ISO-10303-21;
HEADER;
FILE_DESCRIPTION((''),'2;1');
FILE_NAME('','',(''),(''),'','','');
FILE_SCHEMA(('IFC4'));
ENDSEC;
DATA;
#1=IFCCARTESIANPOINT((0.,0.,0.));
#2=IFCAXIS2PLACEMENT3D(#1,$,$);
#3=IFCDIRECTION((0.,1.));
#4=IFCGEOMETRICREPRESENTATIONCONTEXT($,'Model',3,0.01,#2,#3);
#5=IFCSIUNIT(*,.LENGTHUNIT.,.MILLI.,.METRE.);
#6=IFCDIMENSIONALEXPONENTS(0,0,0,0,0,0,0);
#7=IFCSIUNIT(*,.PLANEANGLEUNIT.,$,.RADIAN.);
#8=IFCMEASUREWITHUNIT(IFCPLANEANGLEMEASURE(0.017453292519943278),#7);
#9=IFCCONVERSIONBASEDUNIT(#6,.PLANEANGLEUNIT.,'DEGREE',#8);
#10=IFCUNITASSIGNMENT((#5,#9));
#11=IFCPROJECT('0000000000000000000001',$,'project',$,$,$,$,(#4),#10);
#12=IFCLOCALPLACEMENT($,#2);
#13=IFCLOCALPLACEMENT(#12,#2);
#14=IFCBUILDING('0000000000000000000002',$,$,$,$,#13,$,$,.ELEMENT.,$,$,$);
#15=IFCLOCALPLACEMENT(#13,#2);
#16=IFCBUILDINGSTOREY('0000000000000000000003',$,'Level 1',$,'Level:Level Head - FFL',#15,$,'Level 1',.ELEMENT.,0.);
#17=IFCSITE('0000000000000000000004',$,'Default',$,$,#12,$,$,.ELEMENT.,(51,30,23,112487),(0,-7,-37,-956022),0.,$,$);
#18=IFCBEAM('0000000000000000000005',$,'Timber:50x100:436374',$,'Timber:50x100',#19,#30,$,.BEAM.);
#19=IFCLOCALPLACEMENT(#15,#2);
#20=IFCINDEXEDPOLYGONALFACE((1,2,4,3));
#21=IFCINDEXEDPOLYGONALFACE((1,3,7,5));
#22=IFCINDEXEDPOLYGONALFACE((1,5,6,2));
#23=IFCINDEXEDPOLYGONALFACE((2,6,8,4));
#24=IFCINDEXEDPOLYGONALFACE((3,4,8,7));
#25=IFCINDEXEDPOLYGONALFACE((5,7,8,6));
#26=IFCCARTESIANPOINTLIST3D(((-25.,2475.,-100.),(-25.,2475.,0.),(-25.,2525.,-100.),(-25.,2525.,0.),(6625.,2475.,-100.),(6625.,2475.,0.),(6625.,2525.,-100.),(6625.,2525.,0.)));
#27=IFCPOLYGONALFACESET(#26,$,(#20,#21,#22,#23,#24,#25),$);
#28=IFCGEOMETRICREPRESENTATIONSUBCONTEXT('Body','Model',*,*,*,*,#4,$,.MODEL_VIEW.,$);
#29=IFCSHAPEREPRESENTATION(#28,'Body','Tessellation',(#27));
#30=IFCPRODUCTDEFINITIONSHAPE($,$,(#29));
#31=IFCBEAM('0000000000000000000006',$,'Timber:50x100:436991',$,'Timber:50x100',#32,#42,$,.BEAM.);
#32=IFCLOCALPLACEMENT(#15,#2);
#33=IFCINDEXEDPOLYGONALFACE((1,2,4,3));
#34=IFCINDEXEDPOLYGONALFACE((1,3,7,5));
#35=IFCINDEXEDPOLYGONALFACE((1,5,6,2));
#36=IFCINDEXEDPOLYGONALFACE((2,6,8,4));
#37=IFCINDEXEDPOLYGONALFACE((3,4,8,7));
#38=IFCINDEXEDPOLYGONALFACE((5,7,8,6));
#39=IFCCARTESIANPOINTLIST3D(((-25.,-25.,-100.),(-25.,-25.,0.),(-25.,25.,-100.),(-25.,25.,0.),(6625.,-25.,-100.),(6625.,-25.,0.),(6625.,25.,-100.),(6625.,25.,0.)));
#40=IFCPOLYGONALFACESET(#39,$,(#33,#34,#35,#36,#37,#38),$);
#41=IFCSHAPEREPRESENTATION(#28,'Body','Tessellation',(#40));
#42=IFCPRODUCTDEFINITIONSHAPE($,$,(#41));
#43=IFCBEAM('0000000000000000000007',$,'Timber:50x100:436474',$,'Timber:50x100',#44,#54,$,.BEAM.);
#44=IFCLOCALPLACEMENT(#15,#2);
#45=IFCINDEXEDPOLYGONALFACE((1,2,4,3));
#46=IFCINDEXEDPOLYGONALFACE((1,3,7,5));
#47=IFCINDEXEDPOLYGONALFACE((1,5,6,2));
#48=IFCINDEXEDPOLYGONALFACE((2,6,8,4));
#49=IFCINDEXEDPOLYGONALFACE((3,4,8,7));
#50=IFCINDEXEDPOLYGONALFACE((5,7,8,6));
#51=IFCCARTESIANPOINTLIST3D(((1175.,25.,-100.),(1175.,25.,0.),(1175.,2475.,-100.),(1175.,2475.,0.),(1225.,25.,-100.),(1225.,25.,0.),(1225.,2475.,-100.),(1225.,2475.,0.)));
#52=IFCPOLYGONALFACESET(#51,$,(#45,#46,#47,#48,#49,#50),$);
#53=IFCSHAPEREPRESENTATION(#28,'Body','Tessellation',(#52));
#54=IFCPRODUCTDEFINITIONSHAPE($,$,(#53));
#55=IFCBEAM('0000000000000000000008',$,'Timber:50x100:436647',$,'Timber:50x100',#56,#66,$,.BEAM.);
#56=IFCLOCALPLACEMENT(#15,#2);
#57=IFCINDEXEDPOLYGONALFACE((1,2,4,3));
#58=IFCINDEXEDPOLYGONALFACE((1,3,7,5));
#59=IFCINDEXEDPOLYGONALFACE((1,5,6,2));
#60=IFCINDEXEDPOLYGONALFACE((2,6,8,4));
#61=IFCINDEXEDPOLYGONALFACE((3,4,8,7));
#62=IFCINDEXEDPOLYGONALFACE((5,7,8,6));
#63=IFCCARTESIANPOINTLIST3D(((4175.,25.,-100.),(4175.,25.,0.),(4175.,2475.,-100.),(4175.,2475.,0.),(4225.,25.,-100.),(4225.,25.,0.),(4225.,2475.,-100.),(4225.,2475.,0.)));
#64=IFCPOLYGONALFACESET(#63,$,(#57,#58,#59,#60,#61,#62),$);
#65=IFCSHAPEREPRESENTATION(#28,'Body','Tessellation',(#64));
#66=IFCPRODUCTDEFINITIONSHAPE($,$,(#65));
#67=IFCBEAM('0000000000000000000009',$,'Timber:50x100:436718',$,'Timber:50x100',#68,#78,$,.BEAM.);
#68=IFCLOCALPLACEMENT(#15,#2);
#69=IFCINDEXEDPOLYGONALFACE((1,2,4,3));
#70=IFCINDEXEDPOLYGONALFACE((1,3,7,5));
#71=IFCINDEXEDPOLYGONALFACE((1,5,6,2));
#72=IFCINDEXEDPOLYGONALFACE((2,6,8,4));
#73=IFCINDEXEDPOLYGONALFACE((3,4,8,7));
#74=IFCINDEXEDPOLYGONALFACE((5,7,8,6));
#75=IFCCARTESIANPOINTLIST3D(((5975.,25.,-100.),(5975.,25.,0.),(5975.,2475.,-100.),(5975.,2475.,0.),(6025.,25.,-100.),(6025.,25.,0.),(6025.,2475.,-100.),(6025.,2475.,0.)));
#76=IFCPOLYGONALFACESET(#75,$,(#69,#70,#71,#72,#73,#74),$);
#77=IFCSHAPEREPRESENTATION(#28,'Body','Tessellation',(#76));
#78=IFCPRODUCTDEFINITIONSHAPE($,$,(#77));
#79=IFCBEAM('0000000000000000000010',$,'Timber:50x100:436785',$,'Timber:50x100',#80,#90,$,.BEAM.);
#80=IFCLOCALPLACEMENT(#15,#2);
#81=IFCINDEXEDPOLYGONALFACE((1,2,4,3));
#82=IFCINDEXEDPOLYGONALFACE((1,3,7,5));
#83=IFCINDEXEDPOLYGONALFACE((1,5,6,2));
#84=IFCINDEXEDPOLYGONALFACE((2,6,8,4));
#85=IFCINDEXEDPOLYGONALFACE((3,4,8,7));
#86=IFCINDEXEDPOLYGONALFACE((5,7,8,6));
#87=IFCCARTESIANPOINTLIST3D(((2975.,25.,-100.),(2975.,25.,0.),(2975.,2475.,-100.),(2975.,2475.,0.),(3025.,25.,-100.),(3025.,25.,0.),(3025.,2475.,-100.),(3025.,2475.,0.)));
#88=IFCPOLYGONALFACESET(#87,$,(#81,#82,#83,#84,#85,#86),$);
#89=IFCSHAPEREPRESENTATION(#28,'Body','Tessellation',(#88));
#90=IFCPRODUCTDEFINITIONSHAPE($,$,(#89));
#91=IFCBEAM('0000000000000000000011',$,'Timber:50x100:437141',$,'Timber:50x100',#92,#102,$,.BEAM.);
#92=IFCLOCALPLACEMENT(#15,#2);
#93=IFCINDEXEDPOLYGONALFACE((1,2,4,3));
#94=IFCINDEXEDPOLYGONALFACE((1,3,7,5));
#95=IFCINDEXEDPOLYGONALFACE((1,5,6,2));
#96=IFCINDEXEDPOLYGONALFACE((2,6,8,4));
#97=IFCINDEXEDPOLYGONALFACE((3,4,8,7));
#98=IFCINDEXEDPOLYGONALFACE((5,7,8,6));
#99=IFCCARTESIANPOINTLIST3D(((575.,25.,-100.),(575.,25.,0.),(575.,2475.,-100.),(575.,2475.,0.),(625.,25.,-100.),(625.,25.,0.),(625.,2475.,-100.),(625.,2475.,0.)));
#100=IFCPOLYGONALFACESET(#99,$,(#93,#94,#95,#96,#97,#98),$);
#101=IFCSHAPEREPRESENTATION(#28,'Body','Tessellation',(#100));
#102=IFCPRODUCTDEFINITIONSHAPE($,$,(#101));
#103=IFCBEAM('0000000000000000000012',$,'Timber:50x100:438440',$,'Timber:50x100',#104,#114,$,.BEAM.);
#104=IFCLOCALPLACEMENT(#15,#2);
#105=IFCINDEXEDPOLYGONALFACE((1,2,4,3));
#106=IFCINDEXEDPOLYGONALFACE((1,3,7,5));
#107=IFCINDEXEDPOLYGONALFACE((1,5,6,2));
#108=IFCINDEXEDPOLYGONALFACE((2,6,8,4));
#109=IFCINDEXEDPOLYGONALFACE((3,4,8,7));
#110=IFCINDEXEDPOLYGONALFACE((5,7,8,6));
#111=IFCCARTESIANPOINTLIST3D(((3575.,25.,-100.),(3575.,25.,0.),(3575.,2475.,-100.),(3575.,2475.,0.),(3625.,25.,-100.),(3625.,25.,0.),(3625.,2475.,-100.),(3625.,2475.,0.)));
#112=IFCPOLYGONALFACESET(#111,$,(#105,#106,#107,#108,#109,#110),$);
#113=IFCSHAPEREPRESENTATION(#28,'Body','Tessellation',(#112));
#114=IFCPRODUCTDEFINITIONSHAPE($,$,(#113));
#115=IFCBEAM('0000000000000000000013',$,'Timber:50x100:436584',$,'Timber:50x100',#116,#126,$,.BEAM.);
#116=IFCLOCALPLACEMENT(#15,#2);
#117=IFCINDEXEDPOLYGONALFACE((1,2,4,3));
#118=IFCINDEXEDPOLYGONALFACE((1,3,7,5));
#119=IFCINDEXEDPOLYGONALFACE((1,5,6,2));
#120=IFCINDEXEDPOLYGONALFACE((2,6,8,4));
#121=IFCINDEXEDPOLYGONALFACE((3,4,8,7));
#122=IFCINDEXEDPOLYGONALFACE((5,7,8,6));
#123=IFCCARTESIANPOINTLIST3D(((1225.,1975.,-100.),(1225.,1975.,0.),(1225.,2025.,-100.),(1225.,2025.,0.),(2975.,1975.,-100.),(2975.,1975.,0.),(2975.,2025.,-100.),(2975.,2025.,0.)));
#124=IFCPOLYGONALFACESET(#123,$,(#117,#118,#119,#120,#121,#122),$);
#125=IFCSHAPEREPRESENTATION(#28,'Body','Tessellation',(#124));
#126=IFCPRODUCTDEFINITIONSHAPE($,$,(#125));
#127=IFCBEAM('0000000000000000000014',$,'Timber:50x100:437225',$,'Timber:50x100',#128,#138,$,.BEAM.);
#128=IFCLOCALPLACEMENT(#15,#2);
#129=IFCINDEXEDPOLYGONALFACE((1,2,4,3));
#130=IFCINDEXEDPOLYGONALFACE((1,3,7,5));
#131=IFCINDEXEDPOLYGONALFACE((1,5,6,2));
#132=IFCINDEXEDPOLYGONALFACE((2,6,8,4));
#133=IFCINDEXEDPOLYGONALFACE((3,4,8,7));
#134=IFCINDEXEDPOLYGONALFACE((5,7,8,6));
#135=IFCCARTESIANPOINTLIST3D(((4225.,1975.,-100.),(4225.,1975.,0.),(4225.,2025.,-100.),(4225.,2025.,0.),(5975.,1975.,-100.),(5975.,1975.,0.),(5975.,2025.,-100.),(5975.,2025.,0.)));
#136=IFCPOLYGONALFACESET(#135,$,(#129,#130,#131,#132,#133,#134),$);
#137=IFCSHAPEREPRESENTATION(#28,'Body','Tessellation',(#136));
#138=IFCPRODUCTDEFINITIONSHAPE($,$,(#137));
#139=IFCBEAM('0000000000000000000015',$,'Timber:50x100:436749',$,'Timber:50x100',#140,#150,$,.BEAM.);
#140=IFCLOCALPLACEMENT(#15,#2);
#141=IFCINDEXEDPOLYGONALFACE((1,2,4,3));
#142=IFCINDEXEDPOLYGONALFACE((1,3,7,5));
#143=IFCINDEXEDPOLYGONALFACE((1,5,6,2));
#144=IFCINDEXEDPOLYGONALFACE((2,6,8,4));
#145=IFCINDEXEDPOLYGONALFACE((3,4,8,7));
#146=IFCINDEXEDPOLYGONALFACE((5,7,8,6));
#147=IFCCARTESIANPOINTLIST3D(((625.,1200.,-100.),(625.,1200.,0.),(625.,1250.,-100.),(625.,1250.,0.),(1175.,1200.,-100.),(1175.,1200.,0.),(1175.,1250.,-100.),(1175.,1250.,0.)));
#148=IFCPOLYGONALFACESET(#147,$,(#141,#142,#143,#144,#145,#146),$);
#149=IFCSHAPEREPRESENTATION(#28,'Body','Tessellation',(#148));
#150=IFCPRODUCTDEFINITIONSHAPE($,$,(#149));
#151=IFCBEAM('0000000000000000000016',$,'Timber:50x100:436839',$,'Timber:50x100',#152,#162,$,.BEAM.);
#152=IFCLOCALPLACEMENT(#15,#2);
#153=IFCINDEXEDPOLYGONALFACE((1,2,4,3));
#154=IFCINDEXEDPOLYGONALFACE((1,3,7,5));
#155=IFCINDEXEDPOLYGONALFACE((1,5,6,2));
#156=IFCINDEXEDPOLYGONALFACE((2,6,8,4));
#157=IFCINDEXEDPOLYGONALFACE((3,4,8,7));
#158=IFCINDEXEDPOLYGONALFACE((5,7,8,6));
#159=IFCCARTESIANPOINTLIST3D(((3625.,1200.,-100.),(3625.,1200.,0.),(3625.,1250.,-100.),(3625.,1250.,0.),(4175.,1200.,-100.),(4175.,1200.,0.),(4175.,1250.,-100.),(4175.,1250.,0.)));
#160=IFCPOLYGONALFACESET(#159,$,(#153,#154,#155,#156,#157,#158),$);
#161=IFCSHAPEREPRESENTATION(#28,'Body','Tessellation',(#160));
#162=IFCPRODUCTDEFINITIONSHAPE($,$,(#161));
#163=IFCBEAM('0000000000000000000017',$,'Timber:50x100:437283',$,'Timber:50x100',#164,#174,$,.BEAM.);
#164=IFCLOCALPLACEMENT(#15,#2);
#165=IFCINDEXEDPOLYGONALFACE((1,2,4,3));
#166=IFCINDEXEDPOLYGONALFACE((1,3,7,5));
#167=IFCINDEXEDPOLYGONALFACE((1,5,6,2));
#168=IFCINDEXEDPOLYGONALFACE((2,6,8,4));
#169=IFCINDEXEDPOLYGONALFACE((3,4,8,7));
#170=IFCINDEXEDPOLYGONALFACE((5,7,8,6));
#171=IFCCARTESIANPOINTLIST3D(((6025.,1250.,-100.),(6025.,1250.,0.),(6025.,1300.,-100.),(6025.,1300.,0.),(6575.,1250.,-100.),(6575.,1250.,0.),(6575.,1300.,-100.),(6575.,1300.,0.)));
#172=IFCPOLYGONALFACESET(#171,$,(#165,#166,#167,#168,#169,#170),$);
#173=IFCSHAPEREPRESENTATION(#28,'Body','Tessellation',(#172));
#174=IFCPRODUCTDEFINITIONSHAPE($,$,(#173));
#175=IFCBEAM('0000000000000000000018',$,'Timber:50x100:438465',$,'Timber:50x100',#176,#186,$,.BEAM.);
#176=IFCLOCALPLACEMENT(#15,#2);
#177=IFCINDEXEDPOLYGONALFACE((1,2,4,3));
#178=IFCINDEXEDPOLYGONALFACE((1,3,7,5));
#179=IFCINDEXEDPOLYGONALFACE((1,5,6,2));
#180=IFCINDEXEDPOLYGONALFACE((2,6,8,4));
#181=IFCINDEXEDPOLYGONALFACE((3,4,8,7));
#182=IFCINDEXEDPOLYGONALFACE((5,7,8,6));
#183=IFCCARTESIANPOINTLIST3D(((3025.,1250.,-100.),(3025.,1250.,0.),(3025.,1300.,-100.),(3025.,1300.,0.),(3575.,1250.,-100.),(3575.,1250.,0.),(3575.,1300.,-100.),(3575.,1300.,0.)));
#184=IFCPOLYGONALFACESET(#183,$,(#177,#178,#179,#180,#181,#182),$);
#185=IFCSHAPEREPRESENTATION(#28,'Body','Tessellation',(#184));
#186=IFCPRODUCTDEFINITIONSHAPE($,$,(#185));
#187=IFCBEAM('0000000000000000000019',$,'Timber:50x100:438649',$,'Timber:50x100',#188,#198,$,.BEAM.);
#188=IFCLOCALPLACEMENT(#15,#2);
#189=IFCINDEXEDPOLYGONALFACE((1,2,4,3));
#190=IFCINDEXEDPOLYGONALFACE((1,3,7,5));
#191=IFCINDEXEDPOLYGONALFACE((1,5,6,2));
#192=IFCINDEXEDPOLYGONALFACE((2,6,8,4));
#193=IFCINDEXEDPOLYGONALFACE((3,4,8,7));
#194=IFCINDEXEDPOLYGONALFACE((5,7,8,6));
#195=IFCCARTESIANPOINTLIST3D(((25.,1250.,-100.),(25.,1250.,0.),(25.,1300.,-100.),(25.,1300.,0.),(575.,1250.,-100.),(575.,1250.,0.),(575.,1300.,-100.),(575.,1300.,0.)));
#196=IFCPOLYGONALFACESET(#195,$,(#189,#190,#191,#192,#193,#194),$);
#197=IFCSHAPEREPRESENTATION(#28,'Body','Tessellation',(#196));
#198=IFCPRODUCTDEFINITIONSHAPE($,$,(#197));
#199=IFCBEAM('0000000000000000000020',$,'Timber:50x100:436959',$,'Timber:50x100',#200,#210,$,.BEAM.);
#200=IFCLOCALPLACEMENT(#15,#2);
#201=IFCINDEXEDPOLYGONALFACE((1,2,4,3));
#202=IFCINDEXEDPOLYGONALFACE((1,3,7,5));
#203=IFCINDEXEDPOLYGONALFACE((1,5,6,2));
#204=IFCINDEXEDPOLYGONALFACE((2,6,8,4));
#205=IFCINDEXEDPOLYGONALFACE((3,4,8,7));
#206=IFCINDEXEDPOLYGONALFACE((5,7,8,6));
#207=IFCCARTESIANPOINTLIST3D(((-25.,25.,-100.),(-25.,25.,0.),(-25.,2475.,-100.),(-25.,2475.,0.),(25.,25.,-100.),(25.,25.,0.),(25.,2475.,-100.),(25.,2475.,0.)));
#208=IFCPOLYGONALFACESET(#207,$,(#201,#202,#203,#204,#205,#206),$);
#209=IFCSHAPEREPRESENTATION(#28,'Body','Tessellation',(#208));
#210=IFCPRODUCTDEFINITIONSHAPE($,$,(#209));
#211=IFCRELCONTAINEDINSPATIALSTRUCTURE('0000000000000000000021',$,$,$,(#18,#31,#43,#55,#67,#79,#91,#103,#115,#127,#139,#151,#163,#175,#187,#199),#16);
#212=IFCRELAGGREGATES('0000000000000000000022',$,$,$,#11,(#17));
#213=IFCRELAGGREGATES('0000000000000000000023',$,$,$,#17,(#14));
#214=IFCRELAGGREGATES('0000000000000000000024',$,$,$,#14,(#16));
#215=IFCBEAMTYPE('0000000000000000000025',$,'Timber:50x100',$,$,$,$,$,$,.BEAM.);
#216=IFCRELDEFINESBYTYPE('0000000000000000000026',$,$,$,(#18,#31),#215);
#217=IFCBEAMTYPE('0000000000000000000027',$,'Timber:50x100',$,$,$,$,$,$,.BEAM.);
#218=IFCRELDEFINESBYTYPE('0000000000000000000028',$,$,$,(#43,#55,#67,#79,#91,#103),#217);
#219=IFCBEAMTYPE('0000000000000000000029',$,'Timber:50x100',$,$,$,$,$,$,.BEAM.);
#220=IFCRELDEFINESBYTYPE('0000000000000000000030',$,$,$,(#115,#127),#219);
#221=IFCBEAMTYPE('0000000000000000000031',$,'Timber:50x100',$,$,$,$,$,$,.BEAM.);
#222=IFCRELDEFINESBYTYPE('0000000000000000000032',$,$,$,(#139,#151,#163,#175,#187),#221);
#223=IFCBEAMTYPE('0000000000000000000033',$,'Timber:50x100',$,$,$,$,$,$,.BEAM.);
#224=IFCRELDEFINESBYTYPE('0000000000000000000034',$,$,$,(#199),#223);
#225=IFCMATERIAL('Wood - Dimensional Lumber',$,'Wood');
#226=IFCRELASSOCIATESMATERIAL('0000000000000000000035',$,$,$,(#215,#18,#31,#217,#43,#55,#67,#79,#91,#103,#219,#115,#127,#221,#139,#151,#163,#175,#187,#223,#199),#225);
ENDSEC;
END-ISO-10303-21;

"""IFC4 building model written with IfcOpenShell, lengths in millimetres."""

from ifc_helpers import new_model, entity, si_unit, converted_unit, direction, frame, origin, place, context, subcontext, project, spatial, indexed_curve, outline, extrude, source, transform, mapped, material, type_object, type_shapes, element, save


model = new_model("IFC4")

# Units and contexts
model_context = context("Model", 3, precision=0.01, world=origin(), true_north=direction((0.0, 1.0)))
body_context = subcontext(model_context, "Body", "Model", "MODEL_VIEW")
ifc_project = project(units=[si_unit("LENGTHUNIT", "METRE", prefix="MILLI"), converted_unit("PLANEANGLEUNIT", "DEGREE", entity("IfcPlaneAngleMeasure", 0.017453292519943278), si_unit("PLANEANGLEUNIT", "RADIAN"), dimensions=[0, 0, 0, 0, 0, 0, 0])], contexts=[model_context])

# Site, building, storey
site_placement = place(None, origin())
site = spatial("IfcSite", under=ifc_project, at=site_placement, Name="Default", CompositionType="ELEMENT", RefLatitude=(51, 30, 23, 112487), RefLongitude=(0, -7, -37, -956022), RefElevation=0.0)
building_placement = place(site_placement, origin())
building = spatial("IfcBuilding", under=site, at=building_placement, CompositionType="ELEMENT")
storey_placement = place(building_placement, origin())
storey = spatial("IfcBuildingStorey", under=building, at=storey_placement, Name="Level 1", ObjectType="Level:Level Head - FFL", LongName="Level 1", CompositionType="ELEMENT", Elevation=0.0)

# Beams
ifc_material = material(Name="Wood - Dimensional Lumber", Category="Wood")
beam_type_1 = type_object("IfcBeamType", Name="Timber:50x100", PredefinedType="BEAM", material=ifc_material)
shared_shape_1 = source(origin(), body_context, "Body", "SweptSolid", [
    extrude(outline(indexed_curve([(-3325.0, -25.0), (3325.0, -25.0), (3325.0, 25.0), (-3325.0, 25.0), (-3325.0, -25.0)], self_intersect=False)), frame((0.0, 0.0, -50.0), z_axis=(0.0, 0.0, 1.0), x_axis=(-1.0, 0.0, 0.0)), (0.0, 0.0, 1.0), 100.0),
])
type_shapes(beam_type_1, [shared_shape_1])
for number, where, name in (
    (1, (3300.0, 2500.0, -50.0), "Timber:50x100:436374"),
    (2, (3300.0, 0.0, -50.0), "Timber:50x100:436991"),
):
    element("IfcBeam", number, at=place(storey_placement, frame(where)), inside=storey, type_object=beam_type_1, material=ifc_material, Name=name, ObjectType="Timber:50x100", PredefinedType="BEAM", context=body_context, shape_type="MappedRepresentation", body=[
        mapped(shared_shape_1, transform((0.0, 0.0, 0.0), scale=1.0)),
    ])
beam_type_2 = type_object("IfcBeamType", Name="Timber:50x100", PredefinedType="BEAM", material=ifc_material)
shared_shape_2 = source(origin(), body_context, "Body", "SweptSolid", [
    extrude(outline(indexed_curve([(-1225.0, -25.0), (1225.0, -25.0), (1225.0, 25.0), (-1225.0, 25.0), (-1225.0, -25.0)], self_intersect=False)), frame((0.0, 0.0, -50.0), z_axis=(0.0, 0.0, 1.0), x_axis=(-1.0, 0.0, 0.0)), (0.0, 0.0, 1.0), 100.0),
])
type_shapes(beam_type_2, [shared_shape_2])
for number, where, z_axis, x_axis, name in (
    (3, (1200.0, 1250.0, -50.0), (0.0, 0.0, 1.0), (0.0, -1.0, 0.0), "Timber:50x100:436474"),
    (4, (4200.0, 1250.0, -50.0), (0.0, 0.0, 1.0), (0.0, -1.0, 0.0), "Timber:50x100:436647"),
    (5, (6000.0, 1250.0, -50.0), (0.0, 0.0, 1.0), (0.0, -1.0, 0.0), "Timber:50x100:436718"),
    (6, (3000.0, 1250.0, -50.0), (0.0, 0.0, 1.0), (0.0, -1.0, 0.0), "Timber:50x100:436785"),
    (7, (600.0, 1250.0, -50.0), (0.0, 0.0, 1.0), (0.0, -1.0, 0.0), "Timber:50x100:437141"),
    (8, (3600.0, 1250.0, -50.0), (0.0, 0.0, 1.0), (0.0, -1.0, 0.0), "Timber:50x100:438440"),
):
    element("IfcBeam", number, at=place(storey_placement, frame(where, z_axis=z_axis, x_axis=x_axis)), inside=storey, type_object=beam_type_2, material=ifc_material, Name=name, ObjectType="Timber:50x100", PredefinedType="BEAM", context=body_context, shape_type="MappedRepresentation", body=[
        mapped(shared_shape_2, transform((0.0, 0.0, 0.0), scale=1.0)),
    ])
beam_type_3 = type_object("IfcBeamType", Name="Timber:50x100", PredefinedType="BEAM", material=ifc_material)
shared_shape_3 = source(origin(), body_context, "Body", "SweptSolid", [
    extrude(outline(indexed_curve([(-875.0, -25.0), (875.0, -25.0), (875.0, 25.0), (-875.0, 25.0), (-875.0, -25.0)], self_intersect=False)), frame((0.0, 0.0, -50.0), z_axis=(0.0, 0.0, 1.0), x_axis=(-1.0, 0.0, 0.0)), (0.0, 0.0, 1.0), 100.0),
])
type_shapes(beam_type_3, [shared_shape_3])
for number, where, name in (
    (9, (2100.0, 2000.0, -50.0), "Timber:50x100:436584"),
    (10, (5100.0, 2000.0, -50.0), "Timber:50x100:437225"),
):
    element("IfcBeam", number, at=place(storey_placement, frame(where)), inside=storey, type_object=beam_type_3, material=ifc_material, Name=name, ObjectType="Timber:50x100", PredefinedType="BEAM", context=body_context, shape_type="MappedRepresentation", body=[
        mapped(shared_shape_3, transform((0.0, 0.0, 0.0), scale=1.0)),
    ])
beam_type_4 = type_object("IfcBeamType", Name="Timber:50x100", PredefinedType="BEAM", material=ifc_material)
shared_shape_4 = source(origin(), body_context, "Body", "SweptSolid", [
    extrude(outline(indexed_curve([(-275.0, -25.0), (275.0, -25.0), (275.0, 25.0), (-275.0, 25.0), (-275.0, -25.0)], self_intersect=False)), frame((0.0, 0.0, -50.0), z_axis=(0.0, 0.0, 1.0), x_axis=(-1.0, 0.0, 0.0)), (0.0, 0.0, 1.0), 100.0),
])
type_shapes(beam_type_4, [shared_shape_4])
for number, where, name in (
    (11, (900.0, 1225.0, -50.0), "Timber:50x100:436749"),
    (12, (3900.0, 1225.0, -50.0), "Timber:50x100:436839"),
    (13, (6300.0, 1275.0, -50.0), "Timber:50x100:437283"),
    (14, (3300.0, 1275.0, -50.0), "Timber:50x100:438465"),
    (15, (300.0, 1275.0, -50.0), "Timber:50x100:438649"),
):
    element("IfcBeam", number, at=place(storey_placement, frame(where)), inside=storey, type_object=beam_type_4, material=ifc_material, Name=name, ObjectType="Timber:50x100", PredefinedType="BEAM", context=body_context, shape_type="MappedRepresentation", body=[
        mapped(shared_shape_4, transform((0.0, 0.0, 0.0), scale=1.0)),
    ])
beam_type_5 = type_object("IfcBeamType", Name="Timber:50x100", PredefinedType="BEAM", material=ifc_material)
shared_shape_5 = source(origin(), body_context, "Body", "SweptSolid", [
    extrude(outline(indexed_curve([(-1225.0, -25.0), (1225.0, -25.0), (1225.0, 25.0), (-1225.0, 25.0), (-1225.0, -25.0)], self_intersect=False)), frame((0.0, 0.0, -50.0), z_axis=(0.0, 0.0, 1.0), x_axis=(-1.0, 0.0, 0.0)), (0.0, 0.0, 1.0), 100.0),
])
type_shapes(beam_type_5, [shared_shape_5])
for number, where, z_axis, x_axis, name in (
    (16, (0.0, 1250.0, -50.0), (0.0, 0.0, 1.0), (0.0, -1.0, 0.0), "Timber:50x100:436959"),
):
    element("IfcBeam", number, at=place(storey_placement, frame(where, z_axis=z_axis, x_axis=x_axis)), inside=storey, type_object=beam_type_5, material=ifc_material, Name=name, ObjectType="Timber:50x100", PredefinedType="BEAM", context=body_context, shape_type="MappedRepresentation", body=[
        mapped(shared_shape_5, transform((0.0, 0.0, 0.0), scale=1.0)),
    ])

save(model, "model.ifc")
